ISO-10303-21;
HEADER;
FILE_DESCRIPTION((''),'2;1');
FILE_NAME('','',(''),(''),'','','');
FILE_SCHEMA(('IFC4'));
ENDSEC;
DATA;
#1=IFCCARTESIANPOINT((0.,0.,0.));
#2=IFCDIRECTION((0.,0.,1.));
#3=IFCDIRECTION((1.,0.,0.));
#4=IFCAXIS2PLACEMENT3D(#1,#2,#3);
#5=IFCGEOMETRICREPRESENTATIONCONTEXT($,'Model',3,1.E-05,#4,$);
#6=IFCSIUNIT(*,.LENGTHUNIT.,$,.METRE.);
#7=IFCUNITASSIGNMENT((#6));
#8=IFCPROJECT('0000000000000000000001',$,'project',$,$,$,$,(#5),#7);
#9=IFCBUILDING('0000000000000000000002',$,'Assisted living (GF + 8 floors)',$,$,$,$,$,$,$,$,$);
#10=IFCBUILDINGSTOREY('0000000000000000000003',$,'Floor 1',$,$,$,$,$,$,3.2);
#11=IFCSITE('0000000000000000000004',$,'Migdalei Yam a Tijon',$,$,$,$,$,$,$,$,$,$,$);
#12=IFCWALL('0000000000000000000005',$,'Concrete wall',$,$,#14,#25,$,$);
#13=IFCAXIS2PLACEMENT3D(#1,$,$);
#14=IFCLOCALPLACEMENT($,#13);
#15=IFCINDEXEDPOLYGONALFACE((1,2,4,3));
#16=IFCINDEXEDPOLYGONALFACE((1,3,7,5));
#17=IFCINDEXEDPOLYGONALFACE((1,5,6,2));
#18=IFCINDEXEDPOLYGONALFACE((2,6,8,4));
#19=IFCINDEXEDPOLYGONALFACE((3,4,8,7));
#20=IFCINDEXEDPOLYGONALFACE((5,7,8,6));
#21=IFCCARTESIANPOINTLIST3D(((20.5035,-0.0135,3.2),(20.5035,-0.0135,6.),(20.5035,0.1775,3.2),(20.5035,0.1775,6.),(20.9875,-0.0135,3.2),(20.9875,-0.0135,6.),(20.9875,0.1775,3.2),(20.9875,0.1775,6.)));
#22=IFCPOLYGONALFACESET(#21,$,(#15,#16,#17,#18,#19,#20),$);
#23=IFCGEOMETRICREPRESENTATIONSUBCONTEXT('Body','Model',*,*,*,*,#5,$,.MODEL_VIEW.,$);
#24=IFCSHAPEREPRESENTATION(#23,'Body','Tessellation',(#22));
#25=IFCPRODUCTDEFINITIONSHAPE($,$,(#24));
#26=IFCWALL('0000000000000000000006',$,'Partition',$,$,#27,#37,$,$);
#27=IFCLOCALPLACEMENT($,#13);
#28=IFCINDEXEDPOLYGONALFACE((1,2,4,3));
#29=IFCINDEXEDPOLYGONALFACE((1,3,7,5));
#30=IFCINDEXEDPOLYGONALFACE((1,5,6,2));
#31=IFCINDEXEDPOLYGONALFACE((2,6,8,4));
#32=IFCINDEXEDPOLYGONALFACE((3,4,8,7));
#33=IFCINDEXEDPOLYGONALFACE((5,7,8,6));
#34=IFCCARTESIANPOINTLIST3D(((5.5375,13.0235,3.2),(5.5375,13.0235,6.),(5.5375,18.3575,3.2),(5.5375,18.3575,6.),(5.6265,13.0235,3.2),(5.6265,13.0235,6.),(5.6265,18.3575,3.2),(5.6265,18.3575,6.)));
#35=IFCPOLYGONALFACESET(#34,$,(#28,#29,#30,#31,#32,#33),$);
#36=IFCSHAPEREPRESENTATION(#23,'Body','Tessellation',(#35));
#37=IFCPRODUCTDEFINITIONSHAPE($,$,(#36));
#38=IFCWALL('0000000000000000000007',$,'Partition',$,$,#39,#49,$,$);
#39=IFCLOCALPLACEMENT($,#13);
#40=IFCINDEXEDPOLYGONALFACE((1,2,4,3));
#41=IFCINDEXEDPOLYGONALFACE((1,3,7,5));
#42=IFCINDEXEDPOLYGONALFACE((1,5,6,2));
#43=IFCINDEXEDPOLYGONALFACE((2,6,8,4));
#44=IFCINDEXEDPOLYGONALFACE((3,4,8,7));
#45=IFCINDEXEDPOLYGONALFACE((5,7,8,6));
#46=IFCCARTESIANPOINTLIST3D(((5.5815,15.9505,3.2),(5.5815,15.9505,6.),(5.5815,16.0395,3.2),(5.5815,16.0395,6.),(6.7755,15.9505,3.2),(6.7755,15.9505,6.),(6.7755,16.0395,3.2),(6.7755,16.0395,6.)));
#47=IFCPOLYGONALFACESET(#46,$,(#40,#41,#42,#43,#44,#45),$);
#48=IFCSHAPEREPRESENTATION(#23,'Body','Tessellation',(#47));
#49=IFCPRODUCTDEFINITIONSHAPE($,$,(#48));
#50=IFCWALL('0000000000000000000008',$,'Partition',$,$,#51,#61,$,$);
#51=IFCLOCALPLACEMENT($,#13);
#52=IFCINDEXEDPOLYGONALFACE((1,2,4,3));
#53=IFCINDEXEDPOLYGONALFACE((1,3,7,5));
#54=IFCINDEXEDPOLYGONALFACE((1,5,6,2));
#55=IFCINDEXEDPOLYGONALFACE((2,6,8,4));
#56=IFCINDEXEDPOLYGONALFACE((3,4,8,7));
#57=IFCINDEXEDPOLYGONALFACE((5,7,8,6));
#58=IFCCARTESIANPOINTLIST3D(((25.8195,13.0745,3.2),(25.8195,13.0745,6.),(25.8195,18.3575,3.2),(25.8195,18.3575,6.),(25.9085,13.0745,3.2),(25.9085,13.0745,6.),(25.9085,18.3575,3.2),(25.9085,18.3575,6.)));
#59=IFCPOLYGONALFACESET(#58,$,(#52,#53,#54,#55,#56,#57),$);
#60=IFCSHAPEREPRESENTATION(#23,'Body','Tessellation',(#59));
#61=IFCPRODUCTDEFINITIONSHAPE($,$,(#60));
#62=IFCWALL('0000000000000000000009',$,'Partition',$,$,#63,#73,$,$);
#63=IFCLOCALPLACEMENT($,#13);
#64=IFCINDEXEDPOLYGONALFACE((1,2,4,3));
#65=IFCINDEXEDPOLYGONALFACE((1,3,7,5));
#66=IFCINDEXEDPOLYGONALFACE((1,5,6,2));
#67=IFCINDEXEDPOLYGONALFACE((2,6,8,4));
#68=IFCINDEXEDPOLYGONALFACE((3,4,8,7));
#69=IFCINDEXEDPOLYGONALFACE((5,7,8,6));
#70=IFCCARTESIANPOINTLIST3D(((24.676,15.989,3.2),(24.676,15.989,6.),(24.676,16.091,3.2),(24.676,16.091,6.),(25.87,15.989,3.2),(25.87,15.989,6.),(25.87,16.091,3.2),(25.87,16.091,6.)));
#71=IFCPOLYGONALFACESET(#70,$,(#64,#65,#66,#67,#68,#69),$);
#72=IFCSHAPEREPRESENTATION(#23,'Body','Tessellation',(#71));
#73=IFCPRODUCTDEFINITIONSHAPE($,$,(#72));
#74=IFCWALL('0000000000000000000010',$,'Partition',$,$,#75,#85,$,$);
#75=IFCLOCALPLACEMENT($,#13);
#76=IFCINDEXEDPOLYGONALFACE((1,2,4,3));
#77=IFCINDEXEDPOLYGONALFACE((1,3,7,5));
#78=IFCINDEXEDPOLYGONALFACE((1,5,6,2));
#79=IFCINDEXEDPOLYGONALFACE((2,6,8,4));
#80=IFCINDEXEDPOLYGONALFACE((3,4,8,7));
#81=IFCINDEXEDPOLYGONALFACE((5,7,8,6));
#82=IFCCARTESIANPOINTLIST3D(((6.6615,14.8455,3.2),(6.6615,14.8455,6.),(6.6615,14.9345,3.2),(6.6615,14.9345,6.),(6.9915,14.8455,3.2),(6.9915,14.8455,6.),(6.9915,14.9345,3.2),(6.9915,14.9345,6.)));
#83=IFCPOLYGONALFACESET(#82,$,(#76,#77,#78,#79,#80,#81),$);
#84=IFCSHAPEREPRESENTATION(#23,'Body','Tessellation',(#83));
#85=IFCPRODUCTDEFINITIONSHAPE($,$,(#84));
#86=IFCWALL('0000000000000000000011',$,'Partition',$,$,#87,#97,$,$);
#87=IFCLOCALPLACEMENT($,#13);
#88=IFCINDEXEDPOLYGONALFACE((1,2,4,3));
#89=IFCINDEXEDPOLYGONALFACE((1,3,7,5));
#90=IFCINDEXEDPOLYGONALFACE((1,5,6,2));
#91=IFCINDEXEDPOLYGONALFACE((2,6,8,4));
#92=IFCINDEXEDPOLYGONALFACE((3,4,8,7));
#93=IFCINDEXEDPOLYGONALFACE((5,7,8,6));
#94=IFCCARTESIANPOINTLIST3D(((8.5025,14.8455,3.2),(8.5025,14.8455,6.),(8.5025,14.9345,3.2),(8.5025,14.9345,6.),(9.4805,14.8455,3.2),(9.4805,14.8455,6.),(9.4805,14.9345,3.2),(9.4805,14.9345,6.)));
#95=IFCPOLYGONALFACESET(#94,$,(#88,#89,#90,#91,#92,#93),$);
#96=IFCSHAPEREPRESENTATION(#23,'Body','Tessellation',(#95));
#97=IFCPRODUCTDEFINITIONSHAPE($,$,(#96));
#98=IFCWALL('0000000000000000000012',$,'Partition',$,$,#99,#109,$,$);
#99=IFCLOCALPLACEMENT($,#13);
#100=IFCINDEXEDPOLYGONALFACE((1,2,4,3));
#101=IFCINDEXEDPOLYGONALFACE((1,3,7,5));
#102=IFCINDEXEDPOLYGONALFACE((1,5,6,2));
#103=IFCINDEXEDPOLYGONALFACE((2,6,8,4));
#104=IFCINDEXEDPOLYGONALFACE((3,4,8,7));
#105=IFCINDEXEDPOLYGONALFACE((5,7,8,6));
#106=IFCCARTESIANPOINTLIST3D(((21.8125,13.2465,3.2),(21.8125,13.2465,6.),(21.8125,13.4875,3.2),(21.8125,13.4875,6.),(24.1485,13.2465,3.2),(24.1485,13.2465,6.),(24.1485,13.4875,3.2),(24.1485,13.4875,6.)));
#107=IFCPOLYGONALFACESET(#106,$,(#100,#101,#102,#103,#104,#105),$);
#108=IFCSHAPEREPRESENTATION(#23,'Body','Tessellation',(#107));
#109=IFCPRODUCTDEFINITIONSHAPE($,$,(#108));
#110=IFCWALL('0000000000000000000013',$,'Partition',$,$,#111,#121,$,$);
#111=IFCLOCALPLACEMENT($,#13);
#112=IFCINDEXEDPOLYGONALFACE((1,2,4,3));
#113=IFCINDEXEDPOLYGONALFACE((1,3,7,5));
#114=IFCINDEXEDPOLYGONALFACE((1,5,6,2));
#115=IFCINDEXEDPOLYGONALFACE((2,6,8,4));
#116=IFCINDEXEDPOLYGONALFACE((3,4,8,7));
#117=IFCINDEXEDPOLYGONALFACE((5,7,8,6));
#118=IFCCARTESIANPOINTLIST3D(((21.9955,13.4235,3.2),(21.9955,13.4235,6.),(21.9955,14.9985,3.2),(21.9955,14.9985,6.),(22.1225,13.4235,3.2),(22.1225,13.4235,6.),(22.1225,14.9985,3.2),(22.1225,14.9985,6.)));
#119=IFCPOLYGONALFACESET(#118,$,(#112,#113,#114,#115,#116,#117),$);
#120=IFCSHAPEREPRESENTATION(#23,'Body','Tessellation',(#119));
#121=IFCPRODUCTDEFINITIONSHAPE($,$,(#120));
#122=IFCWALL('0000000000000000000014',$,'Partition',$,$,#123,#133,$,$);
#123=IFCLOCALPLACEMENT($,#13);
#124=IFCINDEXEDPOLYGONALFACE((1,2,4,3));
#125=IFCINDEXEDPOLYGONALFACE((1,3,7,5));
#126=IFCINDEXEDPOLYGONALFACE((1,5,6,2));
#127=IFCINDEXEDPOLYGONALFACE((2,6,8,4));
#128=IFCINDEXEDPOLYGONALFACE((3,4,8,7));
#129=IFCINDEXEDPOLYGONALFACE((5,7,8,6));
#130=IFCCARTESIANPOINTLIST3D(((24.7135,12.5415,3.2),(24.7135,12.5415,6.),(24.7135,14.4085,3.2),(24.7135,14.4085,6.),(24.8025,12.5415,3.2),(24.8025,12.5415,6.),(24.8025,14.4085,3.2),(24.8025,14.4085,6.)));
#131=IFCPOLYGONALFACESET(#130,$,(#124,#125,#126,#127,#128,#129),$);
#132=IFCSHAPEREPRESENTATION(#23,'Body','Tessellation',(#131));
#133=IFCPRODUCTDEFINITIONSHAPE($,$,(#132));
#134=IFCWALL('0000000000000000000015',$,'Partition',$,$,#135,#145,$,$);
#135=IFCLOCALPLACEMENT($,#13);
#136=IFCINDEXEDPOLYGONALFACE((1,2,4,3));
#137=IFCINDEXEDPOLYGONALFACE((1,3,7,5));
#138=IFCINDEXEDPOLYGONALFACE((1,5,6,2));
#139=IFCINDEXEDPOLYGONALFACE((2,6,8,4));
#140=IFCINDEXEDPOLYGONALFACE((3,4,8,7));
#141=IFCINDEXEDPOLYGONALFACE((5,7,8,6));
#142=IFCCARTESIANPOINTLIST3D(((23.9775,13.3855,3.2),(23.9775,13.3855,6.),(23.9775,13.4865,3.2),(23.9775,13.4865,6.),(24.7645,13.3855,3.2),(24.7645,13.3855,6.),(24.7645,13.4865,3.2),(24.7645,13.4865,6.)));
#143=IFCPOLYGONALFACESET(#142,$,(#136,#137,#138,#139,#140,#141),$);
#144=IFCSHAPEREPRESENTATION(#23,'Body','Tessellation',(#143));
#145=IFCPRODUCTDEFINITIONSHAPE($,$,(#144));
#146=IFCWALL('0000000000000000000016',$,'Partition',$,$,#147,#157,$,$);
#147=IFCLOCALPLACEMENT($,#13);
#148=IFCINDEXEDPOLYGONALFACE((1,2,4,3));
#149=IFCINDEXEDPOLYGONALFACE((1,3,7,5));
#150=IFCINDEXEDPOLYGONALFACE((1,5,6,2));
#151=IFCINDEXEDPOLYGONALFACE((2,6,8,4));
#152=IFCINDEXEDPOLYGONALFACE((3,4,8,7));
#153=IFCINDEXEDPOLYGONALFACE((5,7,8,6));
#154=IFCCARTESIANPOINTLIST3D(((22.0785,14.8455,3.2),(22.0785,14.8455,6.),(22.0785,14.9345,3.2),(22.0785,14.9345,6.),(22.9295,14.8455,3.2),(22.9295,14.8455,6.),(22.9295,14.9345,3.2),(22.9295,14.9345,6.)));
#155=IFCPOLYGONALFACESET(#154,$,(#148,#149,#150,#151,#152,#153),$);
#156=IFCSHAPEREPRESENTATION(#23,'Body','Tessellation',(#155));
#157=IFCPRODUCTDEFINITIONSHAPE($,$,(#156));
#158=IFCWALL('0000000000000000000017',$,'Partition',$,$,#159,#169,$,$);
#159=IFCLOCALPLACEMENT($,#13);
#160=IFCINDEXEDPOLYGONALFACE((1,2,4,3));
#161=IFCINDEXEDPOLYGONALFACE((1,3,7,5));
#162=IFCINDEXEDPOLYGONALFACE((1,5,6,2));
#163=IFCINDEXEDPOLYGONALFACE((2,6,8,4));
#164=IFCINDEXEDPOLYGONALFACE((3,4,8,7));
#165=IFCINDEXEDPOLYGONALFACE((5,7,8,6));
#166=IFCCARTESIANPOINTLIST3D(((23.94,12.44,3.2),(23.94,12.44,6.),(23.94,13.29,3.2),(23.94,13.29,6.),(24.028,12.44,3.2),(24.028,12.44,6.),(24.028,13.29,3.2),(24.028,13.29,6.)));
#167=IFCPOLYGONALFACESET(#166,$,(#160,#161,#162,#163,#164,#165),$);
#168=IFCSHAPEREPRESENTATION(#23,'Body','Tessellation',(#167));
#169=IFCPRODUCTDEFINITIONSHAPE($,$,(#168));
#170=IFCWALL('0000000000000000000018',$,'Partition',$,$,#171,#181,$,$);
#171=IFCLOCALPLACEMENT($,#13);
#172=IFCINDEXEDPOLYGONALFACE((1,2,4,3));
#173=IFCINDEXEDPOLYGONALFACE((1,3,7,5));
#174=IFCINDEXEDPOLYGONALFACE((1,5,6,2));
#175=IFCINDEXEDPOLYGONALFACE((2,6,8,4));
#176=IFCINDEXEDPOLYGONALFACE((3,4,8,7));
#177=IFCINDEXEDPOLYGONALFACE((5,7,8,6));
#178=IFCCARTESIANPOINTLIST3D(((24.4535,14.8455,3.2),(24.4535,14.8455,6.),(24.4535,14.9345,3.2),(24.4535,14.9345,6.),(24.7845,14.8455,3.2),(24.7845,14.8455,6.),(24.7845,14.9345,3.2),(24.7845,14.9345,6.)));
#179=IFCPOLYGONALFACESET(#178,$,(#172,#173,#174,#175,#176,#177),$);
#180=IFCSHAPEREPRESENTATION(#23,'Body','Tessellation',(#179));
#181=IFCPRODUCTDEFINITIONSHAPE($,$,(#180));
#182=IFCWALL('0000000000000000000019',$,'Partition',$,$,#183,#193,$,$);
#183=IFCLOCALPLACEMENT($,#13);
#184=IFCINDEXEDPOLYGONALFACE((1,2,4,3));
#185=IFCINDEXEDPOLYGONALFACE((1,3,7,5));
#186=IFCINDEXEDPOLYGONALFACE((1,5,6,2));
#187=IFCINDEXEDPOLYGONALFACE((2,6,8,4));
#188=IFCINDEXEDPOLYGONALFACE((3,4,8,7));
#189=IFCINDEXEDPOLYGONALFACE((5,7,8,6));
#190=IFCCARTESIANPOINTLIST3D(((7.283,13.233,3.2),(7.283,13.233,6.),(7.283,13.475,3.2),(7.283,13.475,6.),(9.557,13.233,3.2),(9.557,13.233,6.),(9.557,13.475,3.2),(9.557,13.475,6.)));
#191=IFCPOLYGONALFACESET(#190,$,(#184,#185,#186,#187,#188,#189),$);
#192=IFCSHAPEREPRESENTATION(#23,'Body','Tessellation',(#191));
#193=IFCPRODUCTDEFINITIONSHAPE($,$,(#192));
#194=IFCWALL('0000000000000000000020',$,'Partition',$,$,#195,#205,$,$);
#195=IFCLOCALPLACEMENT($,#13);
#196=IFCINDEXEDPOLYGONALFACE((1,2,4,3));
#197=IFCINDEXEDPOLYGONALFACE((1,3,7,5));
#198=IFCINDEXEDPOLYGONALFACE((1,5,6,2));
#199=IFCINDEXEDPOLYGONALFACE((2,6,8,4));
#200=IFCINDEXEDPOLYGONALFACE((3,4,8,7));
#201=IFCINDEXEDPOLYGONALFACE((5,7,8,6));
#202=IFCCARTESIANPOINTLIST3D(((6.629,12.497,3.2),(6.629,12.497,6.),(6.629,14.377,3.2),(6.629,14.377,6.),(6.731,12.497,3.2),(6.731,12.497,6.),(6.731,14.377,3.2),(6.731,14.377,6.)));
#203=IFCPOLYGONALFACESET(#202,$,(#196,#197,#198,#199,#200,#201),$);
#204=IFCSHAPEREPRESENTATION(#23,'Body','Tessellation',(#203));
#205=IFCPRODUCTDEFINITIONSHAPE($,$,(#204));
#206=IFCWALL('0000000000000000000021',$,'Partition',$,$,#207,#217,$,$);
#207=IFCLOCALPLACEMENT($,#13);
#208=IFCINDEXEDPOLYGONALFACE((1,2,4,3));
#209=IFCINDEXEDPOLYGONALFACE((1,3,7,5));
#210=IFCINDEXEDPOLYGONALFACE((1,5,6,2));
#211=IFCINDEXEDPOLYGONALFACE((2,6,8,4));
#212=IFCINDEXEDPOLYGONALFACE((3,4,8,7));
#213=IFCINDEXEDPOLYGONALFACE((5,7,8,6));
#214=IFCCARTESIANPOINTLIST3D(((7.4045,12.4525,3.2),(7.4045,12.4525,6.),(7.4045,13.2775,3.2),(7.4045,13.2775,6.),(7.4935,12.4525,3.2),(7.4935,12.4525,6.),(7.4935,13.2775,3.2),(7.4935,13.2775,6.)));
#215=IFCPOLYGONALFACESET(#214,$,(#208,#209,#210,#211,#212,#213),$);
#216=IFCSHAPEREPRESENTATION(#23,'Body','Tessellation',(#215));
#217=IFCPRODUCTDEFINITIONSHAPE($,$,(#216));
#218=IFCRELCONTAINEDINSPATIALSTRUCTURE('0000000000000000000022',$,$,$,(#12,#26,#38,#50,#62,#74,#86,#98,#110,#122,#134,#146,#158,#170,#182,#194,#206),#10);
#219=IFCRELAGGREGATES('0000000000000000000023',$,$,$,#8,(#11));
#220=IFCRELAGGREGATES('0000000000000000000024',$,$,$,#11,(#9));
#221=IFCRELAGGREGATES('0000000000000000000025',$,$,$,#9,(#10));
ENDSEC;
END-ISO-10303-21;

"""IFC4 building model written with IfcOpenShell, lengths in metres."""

from ifc_helpers import new_model, si_unit, frame, origin_with_axes, context, subcontext, project, spatial, line, indexed_curve, outline, extrude, element, save


model = new_model("IFC4")

# Units and contexts
model_context = context("Model", 3, precision=1e-05, world=origin_with_axes())
body_context = subcontext(model_context, "Body", "Model", "MODEL_VIEW")
ifc_project = project(units=[si_unit("LENGTHUNIT", "METRE")], contexts=[model_context])

# Site, building, storey
site = spatial("IfcSite", under=ifc_project, Name="Migdalei Yam a Tijon")
building = spatial("IfcBuilding", under=site, Name="Assisted living (GF + 8 floors)")
storey = spatial("IfcBuildingStorey", under=building, Name="Floor 1", Elevation=3.2)

# Walls
element("IfcWall", 1, inside=storey, Name="Concrete wall", context=body_context, shape_type="SweptSolid", body=[
    extrude(outline(indexed_curve([(0.0, 0.0), (0.484, 0.0), (0.484, 0.191), (0.0, 0.191)], segments=[line(1, 2, 3, 4, 1)])), frame((20.5035, -0.0135, 3.2), z_axis=(0.0, 0.0, 1.0), x_axis=(1.0, 0.0, 0.0)), (0.0, 0.0, 1.0), 2.8),
])
element("IfcWall", 2, inside=storey, Name="Partition", context=body_context, shape_type="SweptSolid", body=[
    extrude(outline(indexed_curve([(0.0, 0.0), (0.089, 0.0), (0.089, 5.334), (0.0, 5.334)], segments=[line(1, 2, 3, 4, 1)])), frame((5.5375, 13.0235, 3.2), z_axis=(0.0, 0.0, 1.0), x_axis=(1.0, 0.0, 0.0)), (0.0, 0.0, 1.0), 2.8),
])
element("IfcWall", 3, inside=storey, Name="Partition", context=body_context, shape_type="SweptSolid", body=[
    extrude(outline(indexed_curve([(0.0, 0.0), (1.194, 0.0), (1.194, 0.089), (0.0, 0.089)], segments=[line(1, 2, 3, 4, 1)])), frame((5.5815, 15.9505, 3.2), z_axis=(0.0, 0.0, 1.0), x_axis=(1.0, 0.0, 0.0)), (0.0, 0.0, 1.0), 2.8),
])
element("IfcWall", 4, inside=storey, Name="Partition", context=body_context, shape_type="SweptSolid", body=[
    extrude(outline(indexed_curve([(0.0, 0.0), (0.089, 0.0), (0.089, 5.283), (0.0, 5.283)], segments=[line(1, 2, 3, 4, 1)])), frame((25.8195, 13.0745, 3.2), z_axis=(0.0, 0.0, 1.0), x_axis=(1.0, 0.0, 0.0)), (0.0, 0.0, 1.0), 2.8),
])
element("IfcWall", 5, inside=storey, Name="Partition", context=body_context, shape_type="SweptSolid", body=[
    extrude(outline(indexed_curve([(0.0, 0.0), (1.194, 0.0), (1.194, 0.102), (0.0, 0.102)], segments=[line(1, 2, 3, 4, 1)])), frame((24.676, 15.989, 3.2), z_axis=(0.0, 0.0, 1.0), x_axis=(1.0, 0.0, 0.0)), (0.0, 0.0, 1.0), 2.8),
])
element("IfcWall", 6, inside=storey, Name="Partition", context=body_context, shape_type="SweptSolid", body=[
    extrude(outline(indexed_curve([(0.0, 0.0), (0.33, 0.0), (0.33, 0.089), (0.0, 0.089)], segments=[line(1, 2, 3, 4, 1)])), frame((6.6615, 14.8455, 3.2), z_axis=(0.0, 0.0, 1.0), x_axis=(1.0, 0.0, 0.0)), (0.0, 0.0, 1.0), 2.8),
])
element("IfcWall", 7, inside=storey, Name="Partition", context=body_context, shape_type="SweptSolid", body=[
    extrude(outline(indexed_curve([(0.0, 0.0), (0.978, 0.0), (0.978, 0.089), (0.0, 0.089)], segments=[line(1, 2, 3, 4, 1)])), frame((8.5025, 14.8455, 3.2), z_axis=(0.0, 0.0, 1.0), x_axis=(1.0, 0.0, 0.0)), (0.0, 0.0, 1.0), 2.8),
])
element("IfcWall", 8, inside=storey, Name="Partition", context=body_context, shape_type="SweptSolid", body=[
    extrude(outline(indexed_curve([(0.0, 0.0), (2.336, 0.0), (2.336, 0.241), (0.0, 0.241)], segments=[line(1, 2, 3, 4, 1)])), frame((21.8125, 13.2465, 3.2), z_axis=(0.0, 0.0, 1.0), x_axis=(1.0, 0.0, 0.0)), (0.0, 0.0, 1.0), 2.8),
])
element("IfcWall", 9, inside=storey, Name="Partition", context=body_context, shape_type="SweptSolid", body=[
    extrude(outline(indexed_curve([(0.0, 0.0), (0.127, 0.0), (0.127, 1.575), (0.0, 1.575)], segments=[line(1, 2, 3, 4, 1)])), frame((21.9955, 13.4235, 3.2), z_axis=(0.0, 0.0, 1.0), x_axis=(1.0, 0.0, 0.0)), (0.0, 0.0, 1.0), 2.8),
])
element("IfcWall", 10, inside=storey, Name="Partition", context=body_context, shape_type="SweptSolid", body=[
    extrude(outline(indexed_curve([(0.0, 0.0), (0.089, 0.0), (0.089, 1.867), (0.0, 1.867)], segments=[line(1, 2, 3, 4, 1)])), frame((24.7135, 12.5415, 3.2), z_axis=(0.0, 0.0, 1.0), x_axis=(1.0, 0.0, 0.0)), (0.0, 0.0, 1.0), 2.8),
])
element("IfcWall", 11, inside=storey, Name="Partition", context=body_context, shape_type="SweptSolid", body=[
    extrude(outline(indexed_curve([(0.0, 0.0), (0.787, 0.0), (0.787, 0.101), (0.0, 0.101)], segments=[line(1, 2, 3, 4, 1)])), frame((23.9775, 13.3855, 3.2), z_axis=(0.0, 0.0, 1.0), x_axis=(1.0, 0.0, 0.0)), (0.0, 0.0, 1.0), 2.8),
])
element("IfcWall", 12, inside=storey, Name="Partition", context=body_context, shape_type="SweptSolid", body=[
    extrude(outline(indexed_curve([(0.0, 0.0), (0.851, 0.0), (0.851, 0.089), (0.0, 0.089)], segments=[line(1, 2, 3, 4, 1)])), frame((22.0785, 14.8455, 3.2), z_axis=(0.0, 0.0, 1.0), x_axis=(1.0, 0.0, 0.0)), (0.0, 0.0, 1.0), 2.8),
])
element("IfcWall", 13, inside=storey, Name="Partition", context=body_context, shape_type="SweptSolid", body=[
    extrude(outline(indexed_curve([(0.0, 0.0), (0.088, 0.0), (0.088, 0.85), (0.0, 0.85)], segments=[line(1, 2, 3, 4, 1)])), frame((23.94, 12.44, 3.2), z_axis=(0.0, 0.0, 1.0), x_axis=(1.0, 0.0, 0.0)), (0.0, 0.0, 1.0), 2.8),
])
element("IfcWall", 14, inside=storey, Name="Partition", context=body_context, shape_type="SweptSolid", body=[
    extrude(outline(indexed_curve([(0.0, 0.0), (0.331, 0.0), (0.331, 0.089), (0.0, 0.089)], segments=[line(1, 2, 3, 4, 1)])), frame((24.4535, 14.8455, 3.2), z_axis=(0.0, 0.0, 1.0), x_axis=(1.0, 0.0, 0.0)), (0.0, 0.0, 1.0), 2.8),
])
element("IfcWall", 15, inside=storey, Name="Partition", context=body_context, shape_type="SweptSolid", body=[
    extrude(outline(indexed_curve([(0.0, 0.0), (2.274, 0.0), (2.274, 0.242), (0.0, 0.242)], segments=[line(1, 2, 3, 4, 1)])), frame((7.283, 13.233, 3.2), z_axis=(0.0, 0.0, 1.0), x_axis=(1.0, 0.0, 0.0)), (0.0, 0.0, 1.0), 2.8),
])
element("IfcWall", 16, inside=storey, Name="Partition", context=body_context, shape_type="SweptSolid", body=[
    extrude(outline(indexed_curve([(0.0, 0.0), (0.102, 0.0), (0.102, 1.88), (0.0, 1.88)], segments=[line(1, 2, 3, 4, 1)])), frame((6.629, 12.497, 3.2), z_axis=(0.0, 0.0, 1.0), x_axis=(1.0, 0.0, 0.0)), (0.0, 0.0, 1.0), 2.8),
])
element("IfcWall", 17, inside=storey, Name="Partition", context=body_context, shape_type="SweptSolid", body=[
    extrude(outline(indexed_curve([(0.0, 0.0), (0.089, 0.0), (0.089, 0.825), (0.0, 0.825)], segments=[line(1, 2, 3, 4, 1)])), frame((7.4045, 12.4525, 3.2), z_axis=(0.0, 0.0, 1.0), x_axis=(1.0, 0.0, 0.0)), (0.0, 0.0, 1.0), 2.8),
])

save(model, "model.ifc")
